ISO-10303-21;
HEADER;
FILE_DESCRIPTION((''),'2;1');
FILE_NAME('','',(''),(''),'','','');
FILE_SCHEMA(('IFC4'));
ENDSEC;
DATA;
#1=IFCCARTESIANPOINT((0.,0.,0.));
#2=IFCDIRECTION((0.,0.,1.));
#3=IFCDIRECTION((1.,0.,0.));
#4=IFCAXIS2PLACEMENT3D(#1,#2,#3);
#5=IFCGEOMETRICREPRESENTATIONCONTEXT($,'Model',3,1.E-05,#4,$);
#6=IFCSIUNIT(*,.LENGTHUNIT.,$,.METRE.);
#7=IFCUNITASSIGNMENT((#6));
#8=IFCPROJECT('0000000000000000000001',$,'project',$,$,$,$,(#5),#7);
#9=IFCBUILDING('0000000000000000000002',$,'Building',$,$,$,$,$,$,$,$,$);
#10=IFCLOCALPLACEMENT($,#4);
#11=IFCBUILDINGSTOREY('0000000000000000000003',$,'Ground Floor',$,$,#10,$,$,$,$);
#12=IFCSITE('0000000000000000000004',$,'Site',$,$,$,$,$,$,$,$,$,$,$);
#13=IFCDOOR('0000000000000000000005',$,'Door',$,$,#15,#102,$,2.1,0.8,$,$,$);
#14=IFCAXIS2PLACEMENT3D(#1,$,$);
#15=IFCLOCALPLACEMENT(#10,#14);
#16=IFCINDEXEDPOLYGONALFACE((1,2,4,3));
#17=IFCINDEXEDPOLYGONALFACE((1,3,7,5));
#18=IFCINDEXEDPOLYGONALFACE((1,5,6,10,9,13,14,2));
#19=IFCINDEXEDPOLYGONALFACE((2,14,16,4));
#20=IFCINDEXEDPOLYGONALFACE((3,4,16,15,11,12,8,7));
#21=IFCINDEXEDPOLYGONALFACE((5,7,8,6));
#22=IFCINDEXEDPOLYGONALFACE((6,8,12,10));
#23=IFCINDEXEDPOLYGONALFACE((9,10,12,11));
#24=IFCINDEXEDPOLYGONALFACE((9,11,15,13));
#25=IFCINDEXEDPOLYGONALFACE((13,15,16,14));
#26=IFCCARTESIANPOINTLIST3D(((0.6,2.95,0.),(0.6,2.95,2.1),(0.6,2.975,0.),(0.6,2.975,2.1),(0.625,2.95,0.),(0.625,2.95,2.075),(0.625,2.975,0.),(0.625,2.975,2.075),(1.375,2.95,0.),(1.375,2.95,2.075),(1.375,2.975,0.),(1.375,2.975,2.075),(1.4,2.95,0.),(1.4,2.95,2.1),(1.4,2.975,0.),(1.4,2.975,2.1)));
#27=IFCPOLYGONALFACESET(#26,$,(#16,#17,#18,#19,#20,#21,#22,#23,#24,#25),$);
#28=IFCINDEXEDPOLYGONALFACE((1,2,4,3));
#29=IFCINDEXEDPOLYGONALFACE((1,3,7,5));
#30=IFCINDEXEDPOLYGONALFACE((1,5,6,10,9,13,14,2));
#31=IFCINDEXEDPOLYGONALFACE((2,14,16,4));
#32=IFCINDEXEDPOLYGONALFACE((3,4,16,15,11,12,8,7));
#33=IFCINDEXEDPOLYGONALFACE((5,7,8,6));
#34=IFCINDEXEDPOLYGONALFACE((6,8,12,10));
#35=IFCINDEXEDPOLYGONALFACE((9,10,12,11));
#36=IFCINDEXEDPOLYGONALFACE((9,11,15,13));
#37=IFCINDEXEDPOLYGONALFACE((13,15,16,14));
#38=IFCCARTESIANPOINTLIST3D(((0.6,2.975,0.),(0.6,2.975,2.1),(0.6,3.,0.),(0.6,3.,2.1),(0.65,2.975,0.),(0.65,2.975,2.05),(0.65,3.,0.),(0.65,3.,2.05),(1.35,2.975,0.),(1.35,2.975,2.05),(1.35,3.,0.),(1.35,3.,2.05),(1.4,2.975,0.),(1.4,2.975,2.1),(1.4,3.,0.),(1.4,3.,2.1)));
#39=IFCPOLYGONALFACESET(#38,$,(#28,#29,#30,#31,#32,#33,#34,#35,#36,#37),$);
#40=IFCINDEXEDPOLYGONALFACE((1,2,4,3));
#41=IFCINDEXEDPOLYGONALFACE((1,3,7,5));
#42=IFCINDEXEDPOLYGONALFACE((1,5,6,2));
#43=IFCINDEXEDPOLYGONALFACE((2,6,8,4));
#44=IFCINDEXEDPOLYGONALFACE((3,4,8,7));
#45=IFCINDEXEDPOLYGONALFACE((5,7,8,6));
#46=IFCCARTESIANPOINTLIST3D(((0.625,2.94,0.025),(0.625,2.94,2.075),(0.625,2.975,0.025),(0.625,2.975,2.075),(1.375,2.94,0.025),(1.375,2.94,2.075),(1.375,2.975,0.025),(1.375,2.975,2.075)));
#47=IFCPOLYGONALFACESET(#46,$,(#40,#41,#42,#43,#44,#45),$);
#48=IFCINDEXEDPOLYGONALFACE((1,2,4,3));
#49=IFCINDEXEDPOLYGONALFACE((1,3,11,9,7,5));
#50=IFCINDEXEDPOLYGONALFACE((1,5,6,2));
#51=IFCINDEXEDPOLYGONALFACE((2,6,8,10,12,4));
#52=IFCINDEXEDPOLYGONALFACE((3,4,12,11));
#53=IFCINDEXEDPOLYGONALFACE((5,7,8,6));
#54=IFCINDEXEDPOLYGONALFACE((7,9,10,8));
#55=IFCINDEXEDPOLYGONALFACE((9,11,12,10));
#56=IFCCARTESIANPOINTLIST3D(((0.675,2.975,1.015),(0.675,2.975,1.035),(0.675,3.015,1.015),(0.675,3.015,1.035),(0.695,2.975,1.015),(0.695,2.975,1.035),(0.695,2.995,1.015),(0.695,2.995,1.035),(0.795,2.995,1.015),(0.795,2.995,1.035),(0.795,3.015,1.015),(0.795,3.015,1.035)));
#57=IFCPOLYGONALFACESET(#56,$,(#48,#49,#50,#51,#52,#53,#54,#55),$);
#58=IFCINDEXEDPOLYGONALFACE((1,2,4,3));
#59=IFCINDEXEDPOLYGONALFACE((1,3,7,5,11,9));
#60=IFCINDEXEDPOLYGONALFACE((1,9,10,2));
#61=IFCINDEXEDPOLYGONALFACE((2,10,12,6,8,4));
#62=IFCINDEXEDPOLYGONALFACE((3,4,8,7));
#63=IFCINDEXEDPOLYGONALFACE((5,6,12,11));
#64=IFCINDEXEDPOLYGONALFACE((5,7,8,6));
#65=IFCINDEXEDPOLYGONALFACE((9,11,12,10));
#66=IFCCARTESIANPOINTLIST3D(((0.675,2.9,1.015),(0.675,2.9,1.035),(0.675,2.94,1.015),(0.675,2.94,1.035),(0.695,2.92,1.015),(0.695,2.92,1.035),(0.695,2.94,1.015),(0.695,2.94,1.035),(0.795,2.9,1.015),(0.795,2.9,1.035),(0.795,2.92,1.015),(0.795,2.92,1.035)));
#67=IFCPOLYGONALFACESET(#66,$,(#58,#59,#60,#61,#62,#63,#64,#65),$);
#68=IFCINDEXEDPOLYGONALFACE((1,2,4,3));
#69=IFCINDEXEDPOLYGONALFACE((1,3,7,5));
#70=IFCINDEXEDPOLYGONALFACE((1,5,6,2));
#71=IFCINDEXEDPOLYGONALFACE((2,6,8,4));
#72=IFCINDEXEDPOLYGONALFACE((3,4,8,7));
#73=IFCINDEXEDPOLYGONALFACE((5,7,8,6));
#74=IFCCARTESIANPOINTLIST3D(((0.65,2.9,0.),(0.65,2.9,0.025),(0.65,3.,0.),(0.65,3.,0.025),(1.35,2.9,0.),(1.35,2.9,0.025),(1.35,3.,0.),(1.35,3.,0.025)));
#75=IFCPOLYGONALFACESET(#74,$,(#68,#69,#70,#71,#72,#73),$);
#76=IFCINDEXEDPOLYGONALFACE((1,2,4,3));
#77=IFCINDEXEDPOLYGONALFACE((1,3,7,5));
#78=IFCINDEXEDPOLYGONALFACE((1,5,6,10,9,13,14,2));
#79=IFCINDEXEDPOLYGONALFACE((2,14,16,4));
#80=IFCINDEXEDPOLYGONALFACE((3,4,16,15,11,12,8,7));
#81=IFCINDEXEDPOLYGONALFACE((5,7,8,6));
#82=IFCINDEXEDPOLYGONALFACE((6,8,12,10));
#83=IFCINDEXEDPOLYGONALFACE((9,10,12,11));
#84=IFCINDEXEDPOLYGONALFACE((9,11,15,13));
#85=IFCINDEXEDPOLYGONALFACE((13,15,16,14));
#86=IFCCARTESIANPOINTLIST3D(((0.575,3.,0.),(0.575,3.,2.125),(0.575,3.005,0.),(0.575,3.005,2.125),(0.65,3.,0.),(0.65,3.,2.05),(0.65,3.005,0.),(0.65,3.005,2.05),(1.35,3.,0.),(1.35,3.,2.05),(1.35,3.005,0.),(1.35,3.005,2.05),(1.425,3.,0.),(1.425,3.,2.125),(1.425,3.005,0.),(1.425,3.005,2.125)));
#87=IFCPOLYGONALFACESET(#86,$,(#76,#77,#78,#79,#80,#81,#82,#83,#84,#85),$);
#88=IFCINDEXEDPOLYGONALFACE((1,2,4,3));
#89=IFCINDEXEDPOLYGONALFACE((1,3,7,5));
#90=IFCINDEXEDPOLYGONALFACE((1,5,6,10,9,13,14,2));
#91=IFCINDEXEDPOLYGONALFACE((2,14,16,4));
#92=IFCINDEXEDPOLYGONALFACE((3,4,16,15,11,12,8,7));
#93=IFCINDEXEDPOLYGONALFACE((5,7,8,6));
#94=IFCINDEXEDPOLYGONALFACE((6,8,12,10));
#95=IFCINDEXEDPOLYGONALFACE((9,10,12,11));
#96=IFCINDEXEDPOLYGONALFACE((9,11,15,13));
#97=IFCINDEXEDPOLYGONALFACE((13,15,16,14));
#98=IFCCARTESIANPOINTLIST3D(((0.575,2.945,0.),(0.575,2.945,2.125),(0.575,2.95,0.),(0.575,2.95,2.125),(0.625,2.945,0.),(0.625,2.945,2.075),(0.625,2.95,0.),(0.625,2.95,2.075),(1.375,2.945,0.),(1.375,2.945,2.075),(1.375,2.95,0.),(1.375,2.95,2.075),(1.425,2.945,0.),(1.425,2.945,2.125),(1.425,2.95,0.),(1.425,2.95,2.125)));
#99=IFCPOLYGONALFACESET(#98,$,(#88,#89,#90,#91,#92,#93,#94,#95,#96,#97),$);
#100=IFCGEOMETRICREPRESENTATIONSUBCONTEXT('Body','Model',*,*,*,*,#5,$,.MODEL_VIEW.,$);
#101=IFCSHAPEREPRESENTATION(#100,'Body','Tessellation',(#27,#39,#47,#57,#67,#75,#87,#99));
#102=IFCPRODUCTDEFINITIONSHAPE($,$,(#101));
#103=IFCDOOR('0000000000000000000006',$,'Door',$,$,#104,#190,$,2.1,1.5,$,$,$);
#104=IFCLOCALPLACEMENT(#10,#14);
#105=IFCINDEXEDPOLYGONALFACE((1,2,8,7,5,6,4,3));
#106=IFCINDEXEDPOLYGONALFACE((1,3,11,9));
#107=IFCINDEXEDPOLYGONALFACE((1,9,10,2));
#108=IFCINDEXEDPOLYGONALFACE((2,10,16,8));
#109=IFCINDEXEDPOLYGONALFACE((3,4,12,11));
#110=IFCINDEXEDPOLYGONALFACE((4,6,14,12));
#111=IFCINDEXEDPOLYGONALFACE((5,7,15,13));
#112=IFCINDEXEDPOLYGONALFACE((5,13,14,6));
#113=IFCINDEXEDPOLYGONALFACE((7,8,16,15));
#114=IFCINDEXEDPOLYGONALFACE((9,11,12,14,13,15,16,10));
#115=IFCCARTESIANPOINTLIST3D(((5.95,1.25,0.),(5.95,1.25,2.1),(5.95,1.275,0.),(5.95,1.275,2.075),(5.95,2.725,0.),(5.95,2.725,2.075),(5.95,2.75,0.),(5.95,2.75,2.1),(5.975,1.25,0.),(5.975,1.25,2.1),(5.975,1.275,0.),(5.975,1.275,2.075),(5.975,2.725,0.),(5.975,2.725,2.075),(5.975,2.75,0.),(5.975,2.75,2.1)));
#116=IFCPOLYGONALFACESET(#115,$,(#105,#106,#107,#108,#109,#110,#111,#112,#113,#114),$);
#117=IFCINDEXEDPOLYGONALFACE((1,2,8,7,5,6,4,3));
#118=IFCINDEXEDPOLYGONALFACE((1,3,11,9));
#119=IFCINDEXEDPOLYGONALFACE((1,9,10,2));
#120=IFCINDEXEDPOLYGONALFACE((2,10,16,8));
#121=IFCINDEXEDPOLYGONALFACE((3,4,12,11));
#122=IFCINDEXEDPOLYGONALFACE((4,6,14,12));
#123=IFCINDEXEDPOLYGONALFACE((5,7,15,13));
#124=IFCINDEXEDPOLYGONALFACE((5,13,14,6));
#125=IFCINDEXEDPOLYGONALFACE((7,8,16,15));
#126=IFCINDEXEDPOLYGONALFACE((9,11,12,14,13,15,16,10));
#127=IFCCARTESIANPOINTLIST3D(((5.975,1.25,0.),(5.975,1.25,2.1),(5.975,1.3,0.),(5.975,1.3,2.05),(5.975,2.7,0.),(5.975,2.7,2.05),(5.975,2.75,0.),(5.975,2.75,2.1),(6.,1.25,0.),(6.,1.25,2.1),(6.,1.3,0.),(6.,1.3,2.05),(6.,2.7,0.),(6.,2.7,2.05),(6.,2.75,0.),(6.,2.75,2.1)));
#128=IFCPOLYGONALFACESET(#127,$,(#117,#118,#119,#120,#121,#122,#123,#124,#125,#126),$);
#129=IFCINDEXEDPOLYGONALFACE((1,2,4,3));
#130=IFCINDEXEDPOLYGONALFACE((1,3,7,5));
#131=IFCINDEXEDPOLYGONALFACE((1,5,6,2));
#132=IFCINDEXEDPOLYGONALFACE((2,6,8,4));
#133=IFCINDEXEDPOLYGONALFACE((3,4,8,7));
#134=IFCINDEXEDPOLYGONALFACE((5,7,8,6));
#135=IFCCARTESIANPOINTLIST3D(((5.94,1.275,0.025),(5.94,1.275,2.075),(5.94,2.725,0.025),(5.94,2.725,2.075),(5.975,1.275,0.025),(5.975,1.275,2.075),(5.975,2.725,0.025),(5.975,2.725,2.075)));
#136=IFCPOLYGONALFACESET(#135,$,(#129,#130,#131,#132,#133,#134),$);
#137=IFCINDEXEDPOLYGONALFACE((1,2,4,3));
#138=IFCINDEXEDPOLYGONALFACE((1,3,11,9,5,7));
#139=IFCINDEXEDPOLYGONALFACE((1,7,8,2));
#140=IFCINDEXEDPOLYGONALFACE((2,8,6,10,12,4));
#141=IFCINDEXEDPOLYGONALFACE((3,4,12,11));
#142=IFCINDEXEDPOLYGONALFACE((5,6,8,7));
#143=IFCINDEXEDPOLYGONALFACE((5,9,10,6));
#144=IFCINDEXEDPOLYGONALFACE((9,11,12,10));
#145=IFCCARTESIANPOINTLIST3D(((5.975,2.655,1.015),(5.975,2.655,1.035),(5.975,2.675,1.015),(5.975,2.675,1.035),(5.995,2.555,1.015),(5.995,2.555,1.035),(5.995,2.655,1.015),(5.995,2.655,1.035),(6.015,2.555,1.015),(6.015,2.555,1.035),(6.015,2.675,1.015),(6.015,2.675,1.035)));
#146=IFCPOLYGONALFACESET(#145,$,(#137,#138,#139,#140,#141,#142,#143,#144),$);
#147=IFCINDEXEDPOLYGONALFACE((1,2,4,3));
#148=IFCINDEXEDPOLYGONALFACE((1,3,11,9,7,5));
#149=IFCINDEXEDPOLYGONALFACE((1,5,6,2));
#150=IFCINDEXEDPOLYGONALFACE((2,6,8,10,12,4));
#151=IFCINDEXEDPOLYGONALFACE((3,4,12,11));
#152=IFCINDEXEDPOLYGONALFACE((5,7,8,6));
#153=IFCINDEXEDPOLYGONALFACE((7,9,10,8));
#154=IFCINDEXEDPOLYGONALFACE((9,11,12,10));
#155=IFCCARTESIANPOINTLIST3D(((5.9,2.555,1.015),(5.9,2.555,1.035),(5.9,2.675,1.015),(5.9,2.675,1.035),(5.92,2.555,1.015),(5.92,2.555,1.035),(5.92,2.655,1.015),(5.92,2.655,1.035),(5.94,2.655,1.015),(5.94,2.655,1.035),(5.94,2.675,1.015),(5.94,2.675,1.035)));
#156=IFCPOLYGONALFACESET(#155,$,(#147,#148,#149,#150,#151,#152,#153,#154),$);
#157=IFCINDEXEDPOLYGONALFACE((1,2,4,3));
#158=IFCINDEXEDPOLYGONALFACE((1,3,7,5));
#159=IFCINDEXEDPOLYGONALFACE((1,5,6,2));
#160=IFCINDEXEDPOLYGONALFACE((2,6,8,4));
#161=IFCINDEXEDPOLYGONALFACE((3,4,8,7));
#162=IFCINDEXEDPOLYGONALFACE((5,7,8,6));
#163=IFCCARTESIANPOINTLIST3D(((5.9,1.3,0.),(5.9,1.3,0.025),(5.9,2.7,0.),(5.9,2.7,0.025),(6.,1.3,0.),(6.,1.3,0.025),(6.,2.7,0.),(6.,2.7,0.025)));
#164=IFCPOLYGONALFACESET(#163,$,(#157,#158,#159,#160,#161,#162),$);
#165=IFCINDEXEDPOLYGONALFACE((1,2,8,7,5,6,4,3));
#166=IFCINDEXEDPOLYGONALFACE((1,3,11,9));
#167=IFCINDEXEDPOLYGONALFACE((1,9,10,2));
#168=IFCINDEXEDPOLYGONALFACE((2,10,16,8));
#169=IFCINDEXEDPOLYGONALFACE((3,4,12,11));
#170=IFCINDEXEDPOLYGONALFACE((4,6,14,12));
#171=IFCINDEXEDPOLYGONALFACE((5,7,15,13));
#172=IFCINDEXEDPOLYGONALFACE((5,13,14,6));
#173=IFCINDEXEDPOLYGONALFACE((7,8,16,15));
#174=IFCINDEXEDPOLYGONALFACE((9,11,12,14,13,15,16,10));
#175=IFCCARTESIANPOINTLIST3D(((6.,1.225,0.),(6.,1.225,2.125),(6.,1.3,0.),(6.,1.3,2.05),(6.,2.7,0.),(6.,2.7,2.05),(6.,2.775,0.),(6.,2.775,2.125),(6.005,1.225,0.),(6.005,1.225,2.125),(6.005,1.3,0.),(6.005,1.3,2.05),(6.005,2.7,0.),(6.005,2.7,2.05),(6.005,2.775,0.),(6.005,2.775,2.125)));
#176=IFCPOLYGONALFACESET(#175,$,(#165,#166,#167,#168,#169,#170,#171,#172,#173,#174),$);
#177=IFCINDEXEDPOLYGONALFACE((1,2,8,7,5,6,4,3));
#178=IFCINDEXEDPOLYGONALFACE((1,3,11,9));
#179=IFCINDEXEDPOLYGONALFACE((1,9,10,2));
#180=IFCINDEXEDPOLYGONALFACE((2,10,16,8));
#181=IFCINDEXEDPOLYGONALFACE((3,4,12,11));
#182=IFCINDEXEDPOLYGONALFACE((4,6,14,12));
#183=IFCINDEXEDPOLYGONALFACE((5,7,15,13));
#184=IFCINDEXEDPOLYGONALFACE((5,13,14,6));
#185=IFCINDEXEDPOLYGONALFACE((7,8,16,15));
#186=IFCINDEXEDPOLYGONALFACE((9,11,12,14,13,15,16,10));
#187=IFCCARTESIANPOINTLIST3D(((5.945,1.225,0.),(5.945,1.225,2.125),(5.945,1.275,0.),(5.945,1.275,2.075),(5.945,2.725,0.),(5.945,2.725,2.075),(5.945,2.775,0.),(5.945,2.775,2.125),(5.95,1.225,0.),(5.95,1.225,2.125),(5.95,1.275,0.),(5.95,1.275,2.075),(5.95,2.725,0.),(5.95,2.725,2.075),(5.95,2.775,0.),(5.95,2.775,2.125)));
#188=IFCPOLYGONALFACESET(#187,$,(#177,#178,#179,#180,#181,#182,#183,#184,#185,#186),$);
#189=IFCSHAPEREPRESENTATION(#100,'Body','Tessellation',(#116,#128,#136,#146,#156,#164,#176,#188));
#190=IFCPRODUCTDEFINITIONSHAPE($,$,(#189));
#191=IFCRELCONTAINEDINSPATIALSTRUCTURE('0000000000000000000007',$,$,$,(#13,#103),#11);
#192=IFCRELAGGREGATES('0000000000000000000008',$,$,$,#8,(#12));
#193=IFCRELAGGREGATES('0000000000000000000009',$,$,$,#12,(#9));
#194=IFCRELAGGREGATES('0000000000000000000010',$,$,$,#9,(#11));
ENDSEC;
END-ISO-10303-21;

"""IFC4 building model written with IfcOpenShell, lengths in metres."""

from ifc_helpers import new_model, si_unit, frame, origin_with_axes, place, context, subcontext, project, spatial, line, indexed_curve, outline, extrude, element, save


model = new_model("IFC4")

# Units and contexts
model_context = context("Model", 3, precision=1e-05, world=origin_with_axes())
body_context = subcontext(model_context, "Body", "Model", "MODEL_VIEW")
ifc_project = project(units=[si_unit("LENGTHUNIT", "METRE")], contexts=[model_context])

# Site, building, storey
site = spatial("IfcSite", under=ifc_project, Name="Site")
building = spatial("IfcBuilding", under=site, Name="Building")
storey_placement = place(None, origin_with_axes())
storey = spatial("IfcBuildingStorey", under=building, at=storey_placement, Name="Ground Floor")

# Doors
door_1_placement = place(storey_placement, frame((1.4, 3.0, 0.0), z_axis=(0.0, 0.0, 1.0), x_axis=(-1.0, 0.0, 0.0)))
element("IfcDoor", 1, at=door_1_placement, inside=storey, Name="Door", OverallHeight=2.1, OverallWidth=0.8, context=body_context, shape_type="SweptSolid", body=[
    extrude(outline(indexed_curve([(0.0, 0.0), (0.0, 2.1), (0.8, 2.1), (0.8, 0.0), (0.775, 0.0), (0.775, 2.075), (0.025, 2.075), (0.025, 0.0)], segments=[line(1, 2, 3, 4, 5, 6, 7, 8, 1)])), frame((0.0, 0.025, 0.0), z_axis=(0.0, -1.0, 0.0), x_axis=(1.0, 0.0, 0.0)), (0.0, 0.0, -1.0), 0.025),
    extrude(outline(indexed_curve([(0.0, 0.0), (0.0, 2.1), (0.8, 2.1), (0.8, 0.0), (0.75, 0.0), (0.75, 2.05), (0.05, 2.05), (0.05, 0.0)], segments=[line(1, 2, 3, 4, 5, 6, 7, 8, 1)])), frame((0.0, 0.0, 0.0), z_axis=(0.0, -1.0, 0.0), x_axis=(1.0, 0.0, 0.0)), (0.0, 0.0, -1.0), 0.025),
    extrude(outline(indexed_curve([(0.0, 0.0), (0.75, 0.0), (0.75, 0.035), (0.0, 0.035)], segments=[line(1, 2, 3, 4, 1)])), frame((0.025, 0.025, 0.025), z_axis=(0.0, 0.0, 1.0), x_axis=(1.0, 0.0, 0.0)), (0.0, 0.0, 1.0), 2.05),
    extrude(outline(indexed_curve([(0.0, 0.0), (0.0, -0.04), (-0.12, -0.04), (-0.12, -0.02), (-0.02, -0.02), (-0.02, 0.0)], segments=[line(1, 2, 3, 4, 5, 6, 1)])), frame((0.725, 0.025, 1.015), z_axis=(0.0, 0.0, 1.0), x_axis=(1.0, 0.0, 0.0)), (0.0, 0.0, 1.0), 0.02),
    extrude(outline(indexed_curve([(0.0, 0.0), (0.0, 0.04), (-0.12, 0.04), (-0.12, 0.02), (-0.02, 0.02), (-0.02, 0.0)], segments=[line(1, 2, 3, 4, 5, 6, 1)])), frame((0.725, 0.06, 1.015), z_axis=(0.0, 0.0, 1.0), x_axis=(1.0, 0.0, 0.0)), (0.0, 0.0, 1.0), 0.02),
    extrude(outline(indexed_curve([(0.0, 0.0), (0.7, 0.0), (0.7, 0.1), (0.0, 0.1)], segments=[line(1, 2, 3, 4, 1)])), frame((0.05, 0.0, 0.0), z_axis=(0.0, 0.0, 1.0), x_axis=(1.0, 0.0, 0.0)), (0.0, 0.0, 1.0), 0.025),
    extrude(outline(indexed_curve([(0.0, 0.0), (0.0, 2.125), (0.85, 2.125), (0.85, 0.0), (0.775, 0.0), (0.775, 2.05), (0.075, 2.05), (0.075, 0.0)], segments=[line(1, 2, 3, 4, 5, 6, 7, 8, 1)])), frame((-0.025, -0.005, 0.0), z_axis=(0.0, -1.0, 0.0), x_axis=(1.0, 0.0, 0.0)), (0.0, 0.0, -1.0), 0.005),
    extrude(outline(indexed_curve([(0.0, 0.0), (0.0, 2.125), (0.85, 2.125), (0.85, 0.0), (0.8, 0.0), (0.8, 2.075), (0.05, 2.075), (0.05, 0.0)], segments=[line(1, 2, 3, 4, 5, 6, 7, 8, 1)])), frame((-0.025, 0.05, 0.0), z_axis=(0.0, -1.0, 0.0), x_axis=(1.0, 0.0, 0.0)), (0.0, 0.0, -1.0), 0.005),
])
door_2_placement = place(storey_placement, frame((6.0, 1.25, 0.0), z_axis=(0.0, 0.0, 1.0), x_axis=(0.0, 1.0, 0.0)))
element("IfcDoor", 2, at=door_2_placement, inside=storey, Name="Door", OverallHeight=2.1, OverallWidth=1.5, context=body_context, shape_type="SweptSolid", body=[
    extrude(outline(indexed_curve([(0.0, 0.0), (0.0, 2.1), (1.5, 2.1), (1.5, 0.0), (1.475, 0.0), (1.475, 2.075), (0.025, 2.075), (0.025, 0.0)], segments=[line(1, 2, 3, 4, 5, 6, 7, 8, 1)])), frame((0.0, 0.025, 0.0), z_axis=(0.0, -1.0, 0.0), x_axis=(1.0, 0.0, 0.0)), (0.0, 0.0, -1.0), 0.025),
    extrude(outline(indexed_curve([(0.0, 0.0), (0.0, 2.1), (1.5, 2.1), (1.5, 0.0), (1.45, 0.0), (1.45, 2.05), (0.05, 2.05), (0.05, 0.0)], segments=[line(1, 2, 3, 4, 5, 6, 7, 8, 1)])), frame((0.0, 0.0, 0.0), z_axis=(0.0, -1.0, 0.0), x_axis=(1.0, 0.0, 0.0)), (0.0, 0.0, -1.0), 0.025),
    extrude(outline(indexed_curve([(0.0, 0.0), (1.45, 0.0), (1.45, 0.035), (0.0, 0.035)], segments=[line(1, 2, 3, 4, 1)])), frame((0.025, 0.025, 0.025), z_axis=(0.0, 0.0, 1.0), x_axis=(1.0, 0.0, 0.0)), (0.0, 0.0, 1.0), 2.05),
    extrude(outline(indexed_curve([(0.0, 0.0), (0.0, -0.04), (-0.12, -0.04), (-0.12, -0.02), (-0.02, -0.02), (-0.02, 0.0)], segments=[line(1, 2, 3, 4, 5, 6, 1)])), frame((1.425, 0.025, 1.015), z_axis=(0.0, 0.0, 1.0), x_axis=(1.0, 0.0, 0.0)), (0.0, 0.0, 1.0), 0.02),
    extrude(outline(indexed_curve([(0.0, 0.0), (0.0, 0.04), (-0.12, 0.04), (-0.12, 0.02), (-0.02, 0.02), (-0.02, 0.0)], segments=[line(1, 2, 3, 4, 5, 6, 1)])), frame((1.425, 0.06, 1.015), z_axis=(0.0, 0.0, 1.0), x_axis=(1.0, 0.0, 0.0)), (0.0, 0.0, 1.0), 0.02),
    extrude(outline(indexed_curve([(0.0, 0.0), (1.4, 0.0), (1.4, 0.1), (0.0, 0.1)], segments=[line(1, 2, 3, 4, 1)])), frame((0.05, 0.0, 0.0), z_axis=(0.0, 0.0, 1.0), x_axis=(1.0, 0.0, 0.0)), (0.0, 0.0, 1.0), 0.025),
    extrude(outline(indexed_curve([(0.0, 0.0), (0.0, 2.125), (1.55, 2.125), (1.55, 0.0), (1.475, 0.0), (1.475, 2.05), (0.075, 2.05), (0.075, 0.0)], segments=[line(1, 2, 3, 4, 5, 6, 7, 8, 1)])), frame((-0.025, -0.005, 0.0), z_axis=(0.0, -1.0, 0.0), x_axis=(1.0, 0.0, 0.0)), (0.0, 0.0, -1.0), 0.005),
    extrude(outline(indexed_curve([(0.0, 0.0), (0.0, 2.125), (1.55, 2.125), (1.55, 0.0), (1.5, 0.0), (1.5, 2.075), (0.05, 2.075), (0.05, 0.0)], segments=[line(1, 2, 3, 4, 5, 6, 7, 8, 1)])), frame((-0.025, 0.05, 0.0), z_axis=(0.0, -1.0, 0.0), x_axis=(1.0, 0.0, 0.0)), (0.0, 0.0, -1.0), 0.005),
])

save(model, "model.ifc")
